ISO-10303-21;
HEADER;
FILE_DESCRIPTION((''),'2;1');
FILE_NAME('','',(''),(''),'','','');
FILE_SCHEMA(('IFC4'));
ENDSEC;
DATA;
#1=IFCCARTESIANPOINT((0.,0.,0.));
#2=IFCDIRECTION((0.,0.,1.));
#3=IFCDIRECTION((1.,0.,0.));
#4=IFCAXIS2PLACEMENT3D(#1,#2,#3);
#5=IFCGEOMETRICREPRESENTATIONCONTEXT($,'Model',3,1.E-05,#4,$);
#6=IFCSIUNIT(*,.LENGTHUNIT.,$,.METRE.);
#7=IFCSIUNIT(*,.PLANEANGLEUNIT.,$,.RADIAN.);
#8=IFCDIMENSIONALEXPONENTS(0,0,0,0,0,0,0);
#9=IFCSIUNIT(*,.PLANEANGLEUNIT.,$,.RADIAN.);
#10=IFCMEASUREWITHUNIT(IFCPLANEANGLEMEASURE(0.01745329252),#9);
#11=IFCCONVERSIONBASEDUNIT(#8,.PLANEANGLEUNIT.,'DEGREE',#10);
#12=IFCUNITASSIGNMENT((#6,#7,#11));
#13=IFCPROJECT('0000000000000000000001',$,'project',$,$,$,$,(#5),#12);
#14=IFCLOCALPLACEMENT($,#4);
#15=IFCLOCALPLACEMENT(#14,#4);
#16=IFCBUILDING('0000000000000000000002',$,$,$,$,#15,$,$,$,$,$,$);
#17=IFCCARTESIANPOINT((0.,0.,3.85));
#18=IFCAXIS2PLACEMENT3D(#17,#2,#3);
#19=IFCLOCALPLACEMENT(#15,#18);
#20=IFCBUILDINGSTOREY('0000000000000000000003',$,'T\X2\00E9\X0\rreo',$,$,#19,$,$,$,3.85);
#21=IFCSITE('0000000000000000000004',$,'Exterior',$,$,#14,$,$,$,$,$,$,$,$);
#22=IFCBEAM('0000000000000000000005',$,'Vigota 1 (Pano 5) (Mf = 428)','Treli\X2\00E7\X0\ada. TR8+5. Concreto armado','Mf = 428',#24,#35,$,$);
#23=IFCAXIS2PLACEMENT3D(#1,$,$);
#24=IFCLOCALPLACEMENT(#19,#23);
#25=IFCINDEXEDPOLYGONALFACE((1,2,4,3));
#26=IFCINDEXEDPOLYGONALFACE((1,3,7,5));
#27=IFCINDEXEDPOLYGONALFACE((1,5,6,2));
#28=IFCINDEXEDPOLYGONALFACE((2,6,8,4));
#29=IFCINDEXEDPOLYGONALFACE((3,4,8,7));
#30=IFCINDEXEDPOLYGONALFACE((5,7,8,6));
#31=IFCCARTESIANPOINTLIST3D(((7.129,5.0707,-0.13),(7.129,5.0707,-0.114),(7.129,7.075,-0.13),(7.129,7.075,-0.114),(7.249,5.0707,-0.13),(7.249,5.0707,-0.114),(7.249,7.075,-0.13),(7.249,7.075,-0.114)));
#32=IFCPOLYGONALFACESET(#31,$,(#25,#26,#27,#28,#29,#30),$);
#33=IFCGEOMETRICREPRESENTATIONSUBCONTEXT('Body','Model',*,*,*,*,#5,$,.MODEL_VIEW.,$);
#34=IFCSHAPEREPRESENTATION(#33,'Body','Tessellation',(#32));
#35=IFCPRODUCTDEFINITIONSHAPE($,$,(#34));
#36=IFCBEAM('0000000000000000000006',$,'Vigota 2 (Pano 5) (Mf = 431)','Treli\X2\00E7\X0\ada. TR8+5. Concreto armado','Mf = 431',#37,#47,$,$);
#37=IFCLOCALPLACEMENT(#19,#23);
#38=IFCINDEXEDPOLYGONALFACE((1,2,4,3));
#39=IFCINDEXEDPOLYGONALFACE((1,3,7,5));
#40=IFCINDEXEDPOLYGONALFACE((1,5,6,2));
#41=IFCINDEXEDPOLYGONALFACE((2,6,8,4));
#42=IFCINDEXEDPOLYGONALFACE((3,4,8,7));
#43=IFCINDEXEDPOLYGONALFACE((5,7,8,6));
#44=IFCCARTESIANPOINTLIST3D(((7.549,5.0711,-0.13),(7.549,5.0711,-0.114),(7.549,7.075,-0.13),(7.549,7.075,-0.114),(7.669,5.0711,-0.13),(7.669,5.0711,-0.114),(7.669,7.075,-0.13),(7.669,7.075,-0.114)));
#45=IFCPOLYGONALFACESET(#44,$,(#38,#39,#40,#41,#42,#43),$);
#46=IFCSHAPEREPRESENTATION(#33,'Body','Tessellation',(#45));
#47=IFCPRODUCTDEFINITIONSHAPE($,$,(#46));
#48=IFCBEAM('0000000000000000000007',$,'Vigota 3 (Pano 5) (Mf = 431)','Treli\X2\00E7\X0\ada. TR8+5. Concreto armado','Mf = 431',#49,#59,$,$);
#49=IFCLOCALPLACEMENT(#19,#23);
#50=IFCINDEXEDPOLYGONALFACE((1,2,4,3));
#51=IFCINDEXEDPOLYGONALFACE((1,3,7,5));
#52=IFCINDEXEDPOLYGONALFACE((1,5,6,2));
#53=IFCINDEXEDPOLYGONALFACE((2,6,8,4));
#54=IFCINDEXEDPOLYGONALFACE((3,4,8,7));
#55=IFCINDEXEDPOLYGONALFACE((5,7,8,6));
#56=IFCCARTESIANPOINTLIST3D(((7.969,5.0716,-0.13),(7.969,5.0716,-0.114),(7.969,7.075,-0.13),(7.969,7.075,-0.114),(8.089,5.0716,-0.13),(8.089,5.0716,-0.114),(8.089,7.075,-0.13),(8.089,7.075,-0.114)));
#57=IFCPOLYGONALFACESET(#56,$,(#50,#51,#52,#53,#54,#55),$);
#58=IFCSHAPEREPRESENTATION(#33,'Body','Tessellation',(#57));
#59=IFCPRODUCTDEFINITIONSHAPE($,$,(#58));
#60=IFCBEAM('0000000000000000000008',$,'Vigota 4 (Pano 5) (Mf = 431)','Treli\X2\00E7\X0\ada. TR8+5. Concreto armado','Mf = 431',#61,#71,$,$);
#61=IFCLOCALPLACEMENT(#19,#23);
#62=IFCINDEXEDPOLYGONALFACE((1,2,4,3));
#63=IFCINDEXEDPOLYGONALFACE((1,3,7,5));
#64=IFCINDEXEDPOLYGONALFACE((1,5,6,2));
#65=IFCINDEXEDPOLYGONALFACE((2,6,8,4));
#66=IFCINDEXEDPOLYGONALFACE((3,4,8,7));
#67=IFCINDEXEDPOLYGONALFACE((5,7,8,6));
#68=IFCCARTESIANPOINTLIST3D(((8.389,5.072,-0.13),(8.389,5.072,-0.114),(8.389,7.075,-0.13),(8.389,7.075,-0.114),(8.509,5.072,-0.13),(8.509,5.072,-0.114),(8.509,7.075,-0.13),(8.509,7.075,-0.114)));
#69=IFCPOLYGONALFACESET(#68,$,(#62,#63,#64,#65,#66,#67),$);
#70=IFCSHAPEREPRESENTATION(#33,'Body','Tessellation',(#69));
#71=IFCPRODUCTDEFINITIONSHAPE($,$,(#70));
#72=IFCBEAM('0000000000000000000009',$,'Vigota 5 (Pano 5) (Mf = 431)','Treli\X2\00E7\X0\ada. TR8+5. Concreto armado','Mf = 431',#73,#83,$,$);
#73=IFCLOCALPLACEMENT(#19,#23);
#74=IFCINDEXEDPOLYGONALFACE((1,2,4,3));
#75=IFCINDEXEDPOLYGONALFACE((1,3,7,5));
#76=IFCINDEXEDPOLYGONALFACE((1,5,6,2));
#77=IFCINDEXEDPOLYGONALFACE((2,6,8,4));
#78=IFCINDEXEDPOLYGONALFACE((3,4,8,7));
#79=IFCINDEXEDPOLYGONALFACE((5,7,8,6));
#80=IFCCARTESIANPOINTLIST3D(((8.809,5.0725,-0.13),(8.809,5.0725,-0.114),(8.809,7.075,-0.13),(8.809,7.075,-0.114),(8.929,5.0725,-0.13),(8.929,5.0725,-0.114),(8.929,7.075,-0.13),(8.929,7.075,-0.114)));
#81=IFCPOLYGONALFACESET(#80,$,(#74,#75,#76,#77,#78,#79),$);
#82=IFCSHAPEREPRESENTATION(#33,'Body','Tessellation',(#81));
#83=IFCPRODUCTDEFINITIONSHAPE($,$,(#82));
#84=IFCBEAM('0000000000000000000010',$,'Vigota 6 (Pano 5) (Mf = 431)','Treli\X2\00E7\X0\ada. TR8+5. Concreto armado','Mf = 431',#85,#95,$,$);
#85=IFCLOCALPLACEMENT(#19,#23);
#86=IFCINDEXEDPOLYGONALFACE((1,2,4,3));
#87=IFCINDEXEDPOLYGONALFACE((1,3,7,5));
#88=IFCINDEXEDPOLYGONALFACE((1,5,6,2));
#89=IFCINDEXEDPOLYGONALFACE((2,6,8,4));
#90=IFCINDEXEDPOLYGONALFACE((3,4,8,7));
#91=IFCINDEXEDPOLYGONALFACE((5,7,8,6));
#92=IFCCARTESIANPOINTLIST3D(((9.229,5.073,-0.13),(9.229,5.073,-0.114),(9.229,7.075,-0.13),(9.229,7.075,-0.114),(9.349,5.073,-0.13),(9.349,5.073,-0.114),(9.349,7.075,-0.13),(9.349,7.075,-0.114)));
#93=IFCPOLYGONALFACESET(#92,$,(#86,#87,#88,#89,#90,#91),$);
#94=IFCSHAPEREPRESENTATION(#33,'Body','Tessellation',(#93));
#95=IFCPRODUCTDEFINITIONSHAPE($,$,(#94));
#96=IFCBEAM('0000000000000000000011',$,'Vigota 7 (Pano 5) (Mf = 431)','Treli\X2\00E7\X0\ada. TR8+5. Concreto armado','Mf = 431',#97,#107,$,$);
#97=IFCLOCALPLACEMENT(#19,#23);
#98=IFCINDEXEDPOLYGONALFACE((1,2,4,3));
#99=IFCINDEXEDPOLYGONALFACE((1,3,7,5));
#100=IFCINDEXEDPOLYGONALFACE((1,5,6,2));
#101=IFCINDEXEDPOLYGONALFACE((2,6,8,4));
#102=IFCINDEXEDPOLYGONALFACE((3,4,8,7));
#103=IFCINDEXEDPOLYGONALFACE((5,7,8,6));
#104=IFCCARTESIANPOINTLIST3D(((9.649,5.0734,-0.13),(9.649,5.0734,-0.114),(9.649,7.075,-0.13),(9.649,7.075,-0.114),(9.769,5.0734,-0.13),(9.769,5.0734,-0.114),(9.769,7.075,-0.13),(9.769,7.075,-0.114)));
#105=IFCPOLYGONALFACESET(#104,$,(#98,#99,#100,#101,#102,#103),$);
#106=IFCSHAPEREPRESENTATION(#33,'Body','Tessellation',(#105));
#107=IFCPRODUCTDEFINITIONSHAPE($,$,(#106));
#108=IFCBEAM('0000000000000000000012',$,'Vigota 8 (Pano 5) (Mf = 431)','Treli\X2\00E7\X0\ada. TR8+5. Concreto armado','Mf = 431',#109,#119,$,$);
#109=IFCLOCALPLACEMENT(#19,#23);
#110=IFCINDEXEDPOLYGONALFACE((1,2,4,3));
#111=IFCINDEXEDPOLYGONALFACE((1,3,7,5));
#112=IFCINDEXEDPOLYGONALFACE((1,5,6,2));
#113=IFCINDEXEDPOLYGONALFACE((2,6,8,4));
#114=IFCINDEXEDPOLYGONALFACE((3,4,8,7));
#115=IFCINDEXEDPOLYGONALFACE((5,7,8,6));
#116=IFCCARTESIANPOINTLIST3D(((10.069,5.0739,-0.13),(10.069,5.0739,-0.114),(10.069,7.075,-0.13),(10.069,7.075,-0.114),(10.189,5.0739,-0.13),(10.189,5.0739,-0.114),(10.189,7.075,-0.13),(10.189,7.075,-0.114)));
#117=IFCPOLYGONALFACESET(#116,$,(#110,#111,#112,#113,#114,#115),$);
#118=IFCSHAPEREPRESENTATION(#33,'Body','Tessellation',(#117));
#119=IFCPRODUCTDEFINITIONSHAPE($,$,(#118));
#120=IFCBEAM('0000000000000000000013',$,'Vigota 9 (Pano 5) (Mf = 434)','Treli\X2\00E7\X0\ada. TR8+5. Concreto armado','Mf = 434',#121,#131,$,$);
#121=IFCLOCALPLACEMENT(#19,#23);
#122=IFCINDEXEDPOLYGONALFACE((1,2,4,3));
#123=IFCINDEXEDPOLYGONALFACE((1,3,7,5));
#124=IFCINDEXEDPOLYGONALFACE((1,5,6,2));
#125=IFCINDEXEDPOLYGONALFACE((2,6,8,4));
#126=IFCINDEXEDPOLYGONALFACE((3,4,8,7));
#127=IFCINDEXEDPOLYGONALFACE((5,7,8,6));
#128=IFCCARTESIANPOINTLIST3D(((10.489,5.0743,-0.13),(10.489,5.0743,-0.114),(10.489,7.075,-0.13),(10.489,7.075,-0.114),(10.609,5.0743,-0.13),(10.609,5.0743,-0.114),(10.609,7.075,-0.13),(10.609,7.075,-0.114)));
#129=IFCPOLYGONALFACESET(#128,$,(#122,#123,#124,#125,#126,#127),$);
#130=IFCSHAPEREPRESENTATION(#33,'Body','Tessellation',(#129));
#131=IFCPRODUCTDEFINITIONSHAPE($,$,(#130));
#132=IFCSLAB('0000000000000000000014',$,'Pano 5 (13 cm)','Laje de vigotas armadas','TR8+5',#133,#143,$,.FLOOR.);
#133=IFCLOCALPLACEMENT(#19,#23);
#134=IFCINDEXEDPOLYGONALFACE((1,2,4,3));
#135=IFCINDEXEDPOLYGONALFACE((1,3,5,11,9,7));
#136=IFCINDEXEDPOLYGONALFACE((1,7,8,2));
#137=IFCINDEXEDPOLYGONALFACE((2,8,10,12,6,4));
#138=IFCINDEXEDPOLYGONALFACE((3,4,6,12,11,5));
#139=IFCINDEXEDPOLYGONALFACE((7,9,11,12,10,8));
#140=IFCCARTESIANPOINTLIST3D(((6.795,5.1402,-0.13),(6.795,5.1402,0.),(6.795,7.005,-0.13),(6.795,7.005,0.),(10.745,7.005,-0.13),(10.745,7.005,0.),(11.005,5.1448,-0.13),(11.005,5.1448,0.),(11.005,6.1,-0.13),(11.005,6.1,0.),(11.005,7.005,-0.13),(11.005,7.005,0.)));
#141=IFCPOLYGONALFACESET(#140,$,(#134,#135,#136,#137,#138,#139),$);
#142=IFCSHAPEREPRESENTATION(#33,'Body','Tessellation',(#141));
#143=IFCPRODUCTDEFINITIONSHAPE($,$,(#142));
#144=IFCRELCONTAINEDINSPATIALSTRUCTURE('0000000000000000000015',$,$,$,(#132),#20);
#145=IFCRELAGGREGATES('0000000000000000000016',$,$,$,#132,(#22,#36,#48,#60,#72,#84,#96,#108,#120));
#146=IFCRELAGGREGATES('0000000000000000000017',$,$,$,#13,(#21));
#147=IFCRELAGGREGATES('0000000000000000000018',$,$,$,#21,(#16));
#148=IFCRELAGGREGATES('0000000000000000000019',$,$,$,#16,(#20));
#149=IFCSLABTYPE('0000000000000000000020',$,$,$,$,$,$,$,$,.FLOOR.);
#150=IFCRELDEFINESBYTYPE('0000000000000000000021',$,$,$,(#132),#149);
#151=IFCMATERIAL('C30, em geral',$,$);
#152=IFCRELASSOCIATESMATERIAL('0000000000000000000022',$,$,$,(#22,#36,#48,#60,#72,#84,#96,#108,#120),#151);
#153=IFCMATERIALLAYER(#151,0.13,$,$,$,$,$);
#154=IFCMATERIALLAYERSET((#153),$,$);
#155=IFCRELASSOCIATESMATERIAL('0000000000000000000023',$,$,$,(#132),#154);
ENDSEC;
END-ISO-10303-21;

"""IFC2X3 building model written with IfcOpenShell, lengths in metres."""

from ifc_helpers import new_model, entity, si_unit, converted_unit, frame, origin_with_axes, place, context, subcontext, project, spatial, polyline, outline, extrude, material, layer, layer_set, layer_usage, type_object, element, aggregate, save


model = new_model("IFC2X3")

# Units and contexts
model_context = context("Model", 3, precision=1e-05, world=origin_with_axes())
body_context = subcontext(model_context, "Body", "Model", "MODEL_VIEW")
ifc_project = project(units=[si_unit("LENGTHUNIT", "METRE"), si_unit("PLANEANGLEUNIT", "RADIAN"), converted_unit("PLANEANGLEUNIT", "DEGREE", entity("IfcPlaneAngleMeasure", 0.01745329252), si_unit("PLANEANGLEUNIT", "RADIAN"), dimensions=[0, 0, 0, 0, 0, 0, 0])], contexts=[model_context])

# Beams
ifc_material = material(Name="C30, em geral")
site_placement = place(None, origin_with_axes())
building_placement = place(site_placement, origin_with_axes())
storey_placement = place(building_placement, frame((0.0, 0.0, 3.85), z_axis=(0.0, 0.0, 1.0), x_axis=(1.0, 0.0, 0.0)))
beam_1_placement = place(storey_placement, frame((7.189, 5.0707, -0.122), z_axis=(0.0, 1.0, 0.0), x_axis=(-1.0, 0.0, 0.0)))
beam_1 = element("IfcBeam", 1, at=beam_1_placement, material=ifc_material, Name="Vigota 1 (Pano 5) (Mf = 428)", Description="Treliçada. TR8+5. Concreto armado", ObjectType="Mf = 428", context=body_context, shape_type="SweptSolid", body=[
    extrude(outline(polyline([(0.06, 0.008), (-0.06, 0.008), (-0.06, -0.008), (0.06, -0.008), (0.06, 0.008)])), origin_with_axes(), (0.0, 0.0, 1.0), 2.0043),
])
beam_2_placement = place(storey_placement, frame((7.609, 5.0711, -0.122), z_axis=(0.0, 1.0, 0.0), x_axis=(-1.0, 0.0, 0.0)))
beam_2 = element("IfcBeam", 2, at=beam_2_placement, material=ifc_material, Name="Vigota 2 (Pano 5) (Mf = 431)", Description="Treliçada. TR8+5. Concreto armado", ObjectType="Mf = 431", context=body_context, shape_type="SweptSolid", body=[
    extrude(outline(polyline([(0.06, 0.008), (-0.06, 0.008), (-0.06, -0.008), (0.06, -0.008), (0.06, 0.008)])), origin_with_axes(), (0.0, 0.0, 1.0), 2.0039),
])
beam_3_placement = place(storey_placement, frame((8.029, 5.0716, -0.122), z_axis=(0.0, 1.0, 0.0), x_axis=(-1.0, 0.0, 0.0)))
beam_3 = element("IfcBeam", 3, at=beam_3_placement, material=ifc_material, Name="Vigota 3 (Pano 5) (Mf = 431)", Description="Treliçada. TR8+5. Concreto armado", ObjectType="Mf = 431", context=body_context, shape_type="SweptSolid", body=[
    extrude(outline(polyline([(0.06, 0.008), (-0.06, 0.008), (-0.06, -0.008), (0.06, -0.008), (0.06, 0.008)])), origin_with_axes(), (0.0, 0.0, 1.0), 2.0034),
])
beam_4_placement = place(storey_placement, frame((8.449, 5.072, -0.122), z_axis=(0.0, 1.0, 0.0), x_axis=(-1.0, 0.0, 0.0)))
beam_4 = element("IfcBeam", 4, at=beam_4_placement, material=ifc_material, Name="Vigota 4 (Pano 5) (Mf = 431)", Description="Treliçada. TR8+5. Concreto armado", ObjectType="Mf = 431", context=body_context, shape_type="SweptSolid", body=[
    extrude(outline(polyline([(0.06, 0.008), (-0.06, 0.008), (-0.06, -0.008), (0.06, -0.008), (0.06, 0.008)])), origin_with_axes(), (0.0, 0.0, 1.0), 2.003),
])
beam_5_placement = place(storey_placement, frame((8.869, 5.0725, -0.122), z_axis=(0.0, 1.0, 0.0), x_axis=(-1.0, 0.0, 0.0)))
beam_5 = element("IfcBeam", 5, at=beam_5_placement, material=ifc_material, Name="Vigota 5 (Pano 5) (Mf = 431)", Description="Treliçada. TR8+5. Concreto armado", ObjectType="Mf = 431", context=body_context, shape_type="SweptSolid", body=[
    extrude(outline(polyline([(0.06, 0.008), (-0.06, 0.008), (-0.06, -0.008), (0.06, -0.008), (0.06, 0.008)])), origin_with_axes(), (0.0, 0.0, 1.0), 2.0025),
])
beam_6_placement = place(storey_placement, frame((9.289, 5.073, -0.122), z_axis=(0.0, 1.0, 0.0), x_axis=(-1.0, 0.0, 0.0)))
beam_6 = element("IfcBeam", 6, at=beam_6_placement, material=ifc_material, Name="Vigota 6 (Pano 5) (Mf = 431)", Description="Treliçada. TR8+5. Concreto armado", ObjectType="Mf = 431", context=body_context, shape_type="SweptSolid", body=[
    extrude(outline(polyline([(0.06, 0.008), (-0.06, 0.008), (-0.06, -0.008), (0.06, -0.008), (0.06, 0.008)])), origin_with_axes(), (0.0, 0.0, 1.0), 2.002),
])
beam_7_placement = place(storey_placement, frame((9.709, 5.0734, -0.122), z_axis=(0.0, 1.0, 0.0), x_axis=(-1.0, 0.0, 0.0)))
beam_7 = element("IfcBeam", 7, at=beam_7_placement, material=ifc_material, Name="Vigota 7 (Pano 5) (Mf = 431)", Description="Treliçada. TR8+5. Concreto armado", ObjectType="Mf = 431", context=body_context, shape_type="SweptSolid", body=[
    extrude(outline(polyline([(0.06, 0.008), (-0.06, 0.008), (-0.06, -0.008), (0.06, -0.008), (0.06, 0.008)])), origin_with_axes(), (0.0, 0.0, 1.0), 2.0016),
])
beam_8_placement = place(storey_placement, frame((10.129, 5.0739, -0.122), z_axis=(0.0, 1.0, 0.0), x_axis=(-1.0, 0.0, 0.0)))
beam_8 = element("IfcBeam", 8, at=beam_8_placement, material=ifc_material, Name="Vigota 8 (Pano 5) (Mf = 431)", Description="Treliçada. TR8+5. Concreto armado", ObjectType="Mf = 431", context=body_context, shape_type="SweptSolid", body=[
    extrude(outline(polyline([(0.06, 0.008), (-0.06, 0.008), (-0.06, -0.008), (0.06, -0.008), (0.06, 0.008)])), origin_with_axes(), (0.0, 0.0, 1.0), 2.0011),
])
beam_9_placement = place(storey_placement, frame((10.549, 5.0743, -0.122), z_axis=(0.0, 1.0, 0.0), x_axis=(-1.0, 0.0, 0.0)))
beam_9 = element("IfcBeam", 9, at=beam_9_placement, material=ifc_material, Name="Vigota 9 (Pano 5) (Mf = 434)", Description="Treliçada. TR8+5. Concreto armado", ObjectType="Mf = 434", context=body_context, shape_type="SweptSolid", body=[
    extrude(outline(polyline([(0.06, 0.008), (-0.06, 0.008), (-0.06, -0.008), (0.06, -0.008), (0.06, 0.008)])), origin_with_axes(), (0.0, 0.0, 1.0), 2.0007),
])

# Site, building, storey
site = spatial("IfcSite", under=ifc_project, at=site_placement, Name="Exterior")
building = spatial("IfcBuilding", under=site, at=building_placement)
storey = spatial("IfcBuildingStorey", under=building, at=storey_placement, Name="Térreo", Elevation=3.85)

# Slab
slab_type = type_object("IfcSlabType", PredefinedType="FLOOR")
ifc_layer_1 = layer(ifc_material, 0.13)
ifc_layer_set_1 = layer_set([ifc_layer_1])
ifc_layer_usage_1 = layer_usage(ifc_layer_set_1, "AXIS3", "POSITIVE", 0.0)
slab_1_placement = place(storey_placement, frame((0.0, 0.0, -0.13), z_axis=(0.0, 0.0, 1.0), x_axis=(1.0, 0.0, 0.0)))
slab_1 = element("IfcSlab", 10, at=slab_1_placement, inside=storey, type_object=slab_type, material=ifc_layer_usage_1, Name="Pano 5 (13 cm)", Description="Laje de vigotas armadas", ObjectType="TR8+5", PredefinedType="FLOOR", context=body_context, shape_type="SweptSolid", body=[
    extrude(outline(polyline([(11.005, 6.1), (11.005, 7.005), (10.745, 7.005), (6.795, 7.005), (6.795, 5.1402), (11.005, 5.1448), (11.005, 6.1)])), origin_with_axes(), (0.0, 0.0, 1.0), 0.13),
])
aggregate(slab_1, [beam_1, beam_2, beam_3, beam_4, beam_5, beam_6, beam_7, beam_8, beam_9])

save(model, "model.ifc")
